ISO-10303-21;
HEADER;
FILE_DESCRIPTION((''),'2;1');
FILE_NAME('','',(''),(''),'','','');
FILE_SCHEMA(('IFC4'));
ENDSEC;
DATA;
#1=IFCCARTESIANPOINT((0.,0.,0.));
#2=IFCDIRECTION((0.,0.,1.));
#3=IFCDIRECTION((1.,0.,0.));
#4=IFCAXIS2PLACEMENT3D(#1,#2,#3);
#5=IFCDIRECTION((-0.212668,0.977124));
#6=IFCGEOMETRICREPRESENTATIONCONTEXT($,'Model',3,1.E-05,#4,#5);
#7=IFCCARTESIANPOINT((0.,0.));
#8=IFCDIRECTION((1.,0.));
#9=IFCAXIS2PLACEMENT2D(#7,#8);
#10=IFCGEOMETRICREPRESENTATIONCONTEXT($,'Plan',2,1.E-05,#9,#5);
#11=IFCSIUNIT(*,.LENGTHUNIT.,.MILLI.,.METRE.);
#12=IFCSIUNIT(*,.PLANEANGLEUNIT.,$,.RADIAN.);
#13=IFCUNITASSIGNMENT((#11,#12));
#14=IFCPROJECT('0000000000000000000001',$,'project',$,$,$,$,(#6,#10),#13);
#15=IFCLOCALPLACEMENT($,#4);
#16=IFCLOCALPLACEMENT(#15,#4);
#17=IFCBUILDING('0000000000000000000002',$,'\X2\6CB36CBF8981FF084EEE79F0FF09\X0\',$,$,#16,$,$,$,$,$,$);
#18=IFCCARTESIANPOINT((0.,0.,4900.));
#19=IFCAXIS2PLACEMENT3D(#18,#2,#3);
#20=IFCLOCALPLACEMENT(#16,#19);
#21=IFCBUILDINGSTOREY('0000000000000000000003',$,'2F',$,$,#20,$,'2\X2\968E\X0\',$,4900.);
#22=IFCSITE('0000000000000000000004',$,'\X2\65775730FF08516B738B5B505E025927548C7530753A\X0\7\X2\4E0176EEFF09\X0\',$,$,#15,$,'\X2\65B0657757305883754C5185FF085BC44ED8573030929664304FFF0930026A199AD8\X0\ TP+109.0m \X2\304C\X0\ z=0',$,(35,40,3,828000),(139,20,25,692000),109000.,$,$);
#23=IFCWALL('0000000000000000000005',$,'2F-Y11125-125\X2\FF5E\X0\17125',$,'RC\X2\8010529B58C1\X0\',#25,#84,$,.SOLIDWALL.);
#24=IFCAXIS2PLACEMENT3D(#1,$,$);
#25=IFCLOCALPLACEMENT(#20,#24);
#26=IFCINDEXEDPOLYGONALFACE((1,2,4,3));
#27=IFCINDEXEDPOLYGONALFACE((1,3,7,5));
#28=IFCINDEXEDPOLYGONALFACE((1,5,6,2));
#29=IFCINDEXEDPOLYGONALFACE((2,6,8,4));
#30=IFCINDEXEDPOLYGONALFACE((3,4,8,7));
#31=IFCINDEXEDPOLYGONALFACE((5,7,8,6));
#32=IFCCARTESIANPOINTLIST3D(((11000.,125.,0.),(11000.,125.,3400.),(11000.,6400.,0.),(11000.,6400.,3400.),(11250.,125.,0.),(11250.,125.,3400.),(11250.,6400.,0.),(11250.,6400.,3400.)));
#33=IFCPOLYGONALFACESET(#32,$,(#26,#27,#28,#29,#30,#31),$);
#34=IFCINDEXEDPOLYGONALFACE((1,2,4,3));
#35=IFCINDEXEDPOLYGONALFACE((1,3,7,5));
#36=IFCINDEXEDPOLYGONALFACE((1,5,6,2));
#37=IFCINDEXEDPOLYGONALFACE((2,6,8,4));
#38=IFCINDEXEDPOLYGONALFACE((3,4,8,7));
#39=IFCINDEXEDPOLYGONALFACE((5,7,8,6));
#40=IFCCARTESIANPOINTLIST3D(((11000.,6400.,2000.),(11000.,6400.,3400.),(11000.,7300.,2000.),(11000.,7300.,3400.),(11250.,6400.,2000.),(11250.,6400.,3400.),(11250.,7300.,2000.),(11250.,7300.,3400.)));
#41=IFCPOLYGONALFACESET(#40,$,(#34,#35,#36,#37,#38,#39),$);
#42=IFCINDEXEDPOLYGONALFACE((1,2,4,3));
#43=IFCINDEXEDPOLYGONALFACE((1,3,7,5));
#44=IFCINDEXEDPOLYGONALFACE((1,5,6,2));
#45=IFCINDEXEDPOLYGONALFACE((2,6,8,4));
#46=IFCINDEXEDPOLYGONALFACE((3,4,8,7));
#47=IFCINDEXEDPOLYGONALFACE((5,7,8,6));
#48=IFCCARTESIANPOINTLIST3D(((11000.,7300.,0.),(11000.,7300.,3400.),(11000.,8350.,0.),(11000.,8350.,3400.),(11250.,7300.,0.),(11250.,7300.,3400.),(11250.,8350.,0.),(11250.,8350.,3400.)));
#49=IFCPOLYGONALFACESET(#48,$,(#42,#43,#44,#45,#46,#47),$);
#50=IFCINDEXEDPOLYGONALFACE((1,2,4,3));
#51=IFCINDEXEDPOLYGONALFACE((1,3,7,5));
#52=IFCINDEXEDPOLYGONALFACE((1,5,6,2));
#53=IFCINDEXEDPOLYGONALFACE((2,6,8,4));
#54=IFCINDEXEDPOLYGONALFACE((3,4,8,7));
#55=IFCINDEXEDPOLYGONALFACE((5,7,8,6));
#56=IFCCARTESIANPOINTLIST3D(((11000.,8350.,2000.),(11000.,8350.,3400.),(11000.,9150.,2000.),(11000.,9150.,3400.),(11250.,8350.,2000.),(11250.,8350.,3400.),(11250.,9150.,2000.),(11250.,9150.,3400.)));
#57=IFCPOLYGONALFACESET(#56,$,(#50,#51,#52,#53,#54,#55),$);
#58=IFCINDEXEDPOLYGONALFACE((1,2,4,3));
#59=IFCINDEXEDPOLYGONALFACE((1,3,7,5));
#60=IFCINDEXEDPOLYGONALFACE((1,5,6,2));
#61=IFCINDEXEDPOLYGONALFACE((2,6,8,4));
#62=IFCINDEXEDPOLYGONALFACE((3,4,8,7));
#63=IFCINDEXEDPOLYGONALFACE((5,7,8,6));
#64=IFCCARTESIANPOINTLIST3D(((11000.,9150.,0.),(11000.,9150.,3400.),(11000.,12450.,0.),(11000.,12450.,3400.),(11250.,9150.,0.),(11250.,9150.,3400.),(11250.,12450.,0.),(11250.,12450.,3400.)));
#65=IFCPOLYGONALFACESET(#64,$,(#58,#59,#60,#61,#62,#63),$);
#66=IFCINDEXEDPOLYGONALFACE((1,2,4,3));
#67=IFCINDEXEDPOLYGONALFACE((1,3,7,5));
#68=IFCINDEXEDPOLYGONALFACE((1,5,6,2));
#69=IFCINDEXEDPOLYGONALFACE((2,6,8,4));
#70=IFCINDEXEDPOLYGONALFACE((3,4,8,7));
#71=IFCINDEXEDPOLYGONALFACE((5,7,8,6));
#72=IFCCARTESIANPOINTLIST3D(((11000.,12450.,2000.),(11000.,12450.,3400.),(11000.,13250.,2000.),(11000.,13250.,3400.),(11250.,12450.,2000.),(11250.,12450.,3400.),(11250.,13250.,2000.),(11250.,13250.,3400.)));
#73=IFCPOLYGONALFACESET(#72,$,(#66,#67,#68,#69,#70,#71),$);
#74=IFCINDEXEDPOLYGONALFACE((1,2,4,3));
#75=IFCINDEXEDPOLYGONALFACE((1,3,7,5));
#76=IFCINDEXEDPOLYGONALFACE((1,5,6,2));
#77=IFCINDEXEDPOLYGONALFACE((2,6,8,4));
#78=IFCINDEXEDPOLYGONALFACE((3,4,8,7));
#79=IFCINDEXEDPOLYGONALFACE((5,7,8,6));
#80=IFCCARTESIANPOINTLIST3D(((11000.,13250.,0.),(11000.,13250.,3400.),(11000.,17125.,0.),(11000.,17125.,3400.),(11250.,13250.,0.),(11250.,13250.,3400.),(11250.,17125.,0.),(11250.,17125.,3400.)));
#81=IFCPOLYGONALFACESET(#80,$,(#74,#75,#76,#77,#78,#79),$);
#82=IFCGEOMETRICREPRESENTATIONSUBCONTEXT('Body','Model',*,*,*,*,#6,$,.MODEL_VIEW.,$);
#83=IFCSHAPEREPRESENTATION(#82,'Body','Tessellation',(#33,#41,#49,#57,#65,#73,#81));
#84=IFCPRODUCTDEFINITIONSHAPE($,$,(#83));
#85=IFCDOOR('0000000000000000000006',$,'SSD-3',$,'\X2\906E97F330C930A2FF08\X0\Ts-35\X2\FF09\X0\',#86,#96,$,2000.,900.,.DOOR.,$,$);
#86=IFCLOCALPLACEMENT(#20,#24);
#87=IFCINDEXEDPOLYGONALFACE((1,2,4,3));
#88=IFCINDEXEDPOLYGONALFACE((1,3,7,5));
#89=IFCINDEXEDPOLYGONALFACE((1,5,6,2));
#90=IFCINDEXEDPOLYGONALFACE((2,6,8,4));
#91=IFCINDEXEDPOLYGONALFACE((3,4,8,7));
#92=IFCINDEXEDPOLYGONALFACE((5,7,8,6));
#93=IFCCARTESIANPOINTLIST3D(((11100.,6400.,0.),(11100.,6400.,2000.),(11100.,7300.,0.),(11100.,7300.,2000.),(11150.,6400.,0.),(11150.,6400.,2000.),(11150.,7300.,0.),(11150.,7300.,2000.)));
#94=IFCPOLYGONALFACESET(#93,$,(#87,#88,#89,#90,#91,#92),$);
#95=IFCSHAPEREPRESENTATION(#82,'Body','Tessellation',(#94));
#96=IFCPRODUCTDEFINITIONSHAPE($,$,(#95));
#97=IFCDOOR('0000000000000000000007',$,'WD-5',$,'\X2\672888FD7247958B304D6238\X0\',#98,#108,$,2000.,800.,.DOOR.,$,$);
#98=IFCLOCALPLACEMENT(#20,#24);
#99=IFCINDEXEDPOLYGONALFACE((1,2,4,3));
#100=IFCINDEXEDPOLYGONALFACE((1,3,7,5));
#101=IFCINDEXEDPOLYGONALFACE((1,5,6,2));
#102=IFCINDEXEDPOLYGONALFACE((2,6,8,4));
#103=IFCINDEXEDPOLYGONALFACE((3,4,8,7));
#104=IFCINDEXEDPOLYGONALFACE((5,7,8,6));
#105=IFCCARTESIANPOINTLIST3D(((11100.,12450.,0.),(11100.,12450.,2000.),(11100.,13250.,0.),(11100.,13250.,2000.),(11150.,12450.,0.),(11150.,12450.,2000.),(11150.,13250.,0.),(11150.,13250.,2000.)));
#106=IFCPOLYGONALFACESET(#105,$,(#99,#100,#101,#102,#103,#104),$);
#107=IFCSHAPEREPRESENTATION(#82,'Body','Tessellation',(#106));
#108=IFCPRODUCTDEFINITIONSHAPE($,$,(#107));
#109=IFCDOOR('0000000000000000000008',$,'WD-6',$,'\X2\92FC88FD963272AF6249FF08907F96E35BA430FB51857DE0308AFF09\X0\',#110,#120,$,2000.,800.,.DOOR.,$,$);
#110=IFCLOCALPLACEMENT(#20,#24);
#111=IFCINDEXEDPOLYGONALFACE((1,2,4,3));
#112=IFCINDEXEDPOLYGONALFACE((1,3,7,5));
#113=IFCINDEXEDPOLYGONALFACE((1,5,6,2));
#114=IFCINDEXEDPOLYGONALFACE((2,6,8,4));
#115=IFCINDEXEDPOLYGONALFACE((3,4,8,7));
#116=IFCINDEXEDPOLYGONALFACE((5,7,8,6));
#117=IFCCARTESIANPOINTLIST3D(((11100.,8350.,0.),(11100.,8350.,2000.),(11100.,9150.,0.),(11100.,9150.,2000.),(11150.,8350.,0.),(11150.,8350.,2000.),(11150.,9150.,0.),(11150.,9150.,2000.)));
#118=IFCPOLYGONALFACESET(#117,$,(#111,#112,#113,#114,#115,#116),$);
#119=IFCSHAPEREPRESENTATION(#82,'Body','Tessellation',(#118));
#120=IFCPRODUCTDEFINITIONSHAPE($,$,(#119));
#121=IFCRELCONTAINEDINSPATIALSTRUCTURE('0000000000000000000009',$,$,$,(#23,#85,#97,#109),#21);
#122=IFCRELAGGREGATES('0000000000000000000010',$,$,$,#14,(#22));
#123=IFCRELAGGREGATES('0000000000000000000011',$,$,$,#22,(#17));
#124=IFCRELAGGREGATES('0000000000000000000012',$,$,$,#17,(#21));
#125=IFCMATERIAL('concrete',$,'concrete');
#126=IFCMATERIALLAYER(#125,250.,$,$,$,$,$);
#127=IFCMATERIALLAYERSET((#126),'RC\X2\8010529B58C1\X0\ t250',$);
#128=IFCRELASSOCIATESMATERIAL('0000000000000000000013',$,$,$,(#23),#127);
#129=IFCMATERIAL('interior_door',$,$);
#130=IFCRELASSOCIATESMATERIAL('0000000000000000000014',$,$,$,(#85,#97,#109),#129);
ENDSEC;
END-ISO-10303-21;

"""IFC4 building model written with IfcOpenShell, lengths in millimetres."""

from ifc_helpers import new_model, si_unit, direction, frame, frame_2d, origin, origin_with_axes, origin_2d_with_axis, place, context, subcontext, project, spatial, rectangle, extrude, material, layer, layer_set, layer_usage, element, fill, save


model = new_model("IFC4")

# Units and contexts
model_context = context("Model", 3, precision=1e-05, world=origin_with_axes(), true_north=direction((-0.212668, 0.977124)))
plan_context = context("Plan", 2, precision=1e-05, world=origin_2d_with_axis(), true_north=direction((-0.212668, 0.977124)))
body_context = subcontext(model_context, "Body", "Model", "MODEL_VIEW")
ifc_project = project(units=[si_unit("LENGTHUNIT", "METRE", prefix="MILLI"), si_unit("PLANEANGLEUNIT", "RADIAN")], contexts=[model_context, plan_context])

# Site, building, storey
site_placement = place(None, origin_with_axes())
site = spatial("IfcSite", under=ifc_project, at=site_placement, Name="敷地（八王子市大和田町7丁目）", LongName="新敷地境界内（寄付地を除く）。標高 TP+109.0m が z=0", RefLatitude=(35, 40, 3, 828000), RefLongitude=(139, 20, 25, 692000), RefElevation=109000.0)
building_placement = place(site_placement, origin_with_axes())
building = spatial("IfcBuilding", under=site, at=building_placement, Name="河沿要（仮称）")
storey_placement = place(building_placement, frame((0.0, 0.0, 4900.0), z_axis=(0.0, 0.0, 1.0), x_axis=(1.0, 0.0, 0.0)))
storey = spatial("IfcBuildingStorey", under=building, at=storey_placement, Name="2F", LongName="2階", Elevation=4900.0)

# Wall, openings, doors
ifc_material_1 = material(Name="concrete", Category="concrete")
ifc_layer_1 = layer(ifc_material_1, 250.0)
ifc_layer_set_1 = layer_set([ifc_layer_1], Name="RC耐力壁 t250")
ifc_layer_usage_1 = layer_usage(ifc_layer_set_1, "AXIS2", "POSITIVE", 0.0)
wall_1_placement = place(storey_placement, origin_with_axes())
wall_1 = element("IfcWall", 1, at=wall_1_placement, inside=storey, material=ifc_layer_usage_1, Name="2F-Y11125-125～17125", ObjectType="RC耐力壁", PredefinedType="SOLIDWALL", context=body_context, shape_type="SweptSolid", body=[
    extrude(rectangle(XDim=250.0, YDim=6275.0, at=frame_2d((11125.0, 3262.5))), origin(), (0.0, 0.0, 1.0), 3400.0),
    extrude(rectangle(XDim=250.0, YDim=900.0, at=frame_2d((11125.0, 6850.0))), frame((0.0, 0.0, 2000.0)), (0.0, 0.0, 1.0), 1400.0),
    extrude(rectangle(XDim=250.0, YDim=1050.0, at=frame_2d((11125.0, 7825.0))), origin(), (0.0, 0.0, 1.0), 3400.0),
    extrude(rectangle(XDim=250.0, YDim=800.0, at=frame_2d((11125.0, 8750.0))), frame((0.0, 0.0, 2000.0)), (0.0, 0.0, 1.0), 1400.0),
    extrude(rectangle(XDim=250.0, YDim=3300.0, at=frame_2d((11125.0, 10800.0))), origin(), (0.0, 0.0, 1.0), 3400.0),
    extrude(rectangle(XDim=250.0, YDim=800.0, at=frame_2d((11125.0, 12850.0))), frame((0.0, 0.0, 2000.0)), (0.0, 0.0, 1.0), 1400.0),
    extrude(rectangle(XDim=250.0, YDim=3875.0, at=frame_2d((11125.0, 15187.5))), origin(), (0.0, 0.0, 1.0), 3400.0),
])
opening_1_placement = place(storey_placement, origin_with_axes())
opening_1 = element("IfcOpeningElement", 2, at=opening_1_placement, inside=storey, cuts=wall_1, PredefinedType="OPENING", context=body_context, shape_type="SweptSolid", body=[
    extrude(rectangle(XDim=300.0, YDim=900.0, at=frame_2d((11125.0, 6850.0))), origin(), (0.0, 0.0, 1.0), 2000.0),
])
opening_2_placement = place(storey_placement, origin_with_axes())
opening_2 = element("IfcOpeningElement", 3, at=opening_2_placement, inside=storey, cuts=wall_1, PredefinedType="OPENING", context=body_context, shape_type="SweptSolid", body=[
    extrude(rectangle(XDim=300.0, YDim=800.0, at=frame_2d((11125.0, 12850.0))), origin(), (0.0, 0.0, 1.0), 2000.0),
])
opening_3_placement = place(storey_placement, origin_with_axes())
opening_3 = element("IfcOpeningElement", 4, at=opening_3_placement, inside=storey, cuts=wall_1, PredefinedType="OPENING", context=body_context, shape_type="SweptSolid", body=[
    extrude(rectangle(XDim=300.0, YDim=800.0, at=frame_2d((11125.0, 8750.0))), origin(), (0.0, 0.0, 1.0), 2000.0),
])
ifc_material_2 = material(Name="interior_door")
door_1_placement = place(storey_placement, origin_with_axes())
door_1 = element("IfcDoor", 5, at=door_1_placement, inside=storey, material=ifc_material_2, Name="SSD-3", ObjectType="遮音ドア（Ts-35）", OverallHeight=2000.0, OverallWidth=900.0, PredefinedType="DOOR", context=body_context, shape_type="SweptSolid", body=[
    extrude(rectangle(XDim=50.0, YDim=900.0, at=frame_2d((11125.0, 6850.0))), origin(), (0.0, 0.0, 1.0), 2000.0),
])
fill(opening_1, door_1)
door_2_placement = place(storey_placement, origin_with_axes())
door_2 = element("IfcDoor", 6, at=door_2_placement, inside=storey, material=ifc_material_2, Name="WD-5", ObjectType="木製片開き戸", OverallHeight=2000.0, OverallWidth=800.0, PredefinedType="DOOR", context=body_context, shape_type="SweptSolid", body=[
    extrude(rectangle(XDim=50.0, YDim=800.0, at=frame_2d((11125.0, 12850.0))), origin(), (0.0, 0.0, 1.0), 2000.0),
])
fill(opening_2, door_2)
door_3_placement = place(storey_placement, origin_with_axes())
door_3 = element("IfcDoor", 7, at=door_3_placement, inside=storey, material=ifc_material_2, Name="WD-6", ObjectType="鋼製防犯扉（避難室・内締り）", OverallHeight=2000.0, OverallWidth=800.0, PredefinedType="DOOR", context=body_context, shape_type="SweptSolid", body=[
    extrude(rectangle(XDim=50.0, YDim=800.0, at=frame_2d((11125.0, 8750.0))), origin(), (0.0, 0.0, 1.0), 2000.0),
])
fill(opening_3, door_3)

save(model, "model.ifc")
